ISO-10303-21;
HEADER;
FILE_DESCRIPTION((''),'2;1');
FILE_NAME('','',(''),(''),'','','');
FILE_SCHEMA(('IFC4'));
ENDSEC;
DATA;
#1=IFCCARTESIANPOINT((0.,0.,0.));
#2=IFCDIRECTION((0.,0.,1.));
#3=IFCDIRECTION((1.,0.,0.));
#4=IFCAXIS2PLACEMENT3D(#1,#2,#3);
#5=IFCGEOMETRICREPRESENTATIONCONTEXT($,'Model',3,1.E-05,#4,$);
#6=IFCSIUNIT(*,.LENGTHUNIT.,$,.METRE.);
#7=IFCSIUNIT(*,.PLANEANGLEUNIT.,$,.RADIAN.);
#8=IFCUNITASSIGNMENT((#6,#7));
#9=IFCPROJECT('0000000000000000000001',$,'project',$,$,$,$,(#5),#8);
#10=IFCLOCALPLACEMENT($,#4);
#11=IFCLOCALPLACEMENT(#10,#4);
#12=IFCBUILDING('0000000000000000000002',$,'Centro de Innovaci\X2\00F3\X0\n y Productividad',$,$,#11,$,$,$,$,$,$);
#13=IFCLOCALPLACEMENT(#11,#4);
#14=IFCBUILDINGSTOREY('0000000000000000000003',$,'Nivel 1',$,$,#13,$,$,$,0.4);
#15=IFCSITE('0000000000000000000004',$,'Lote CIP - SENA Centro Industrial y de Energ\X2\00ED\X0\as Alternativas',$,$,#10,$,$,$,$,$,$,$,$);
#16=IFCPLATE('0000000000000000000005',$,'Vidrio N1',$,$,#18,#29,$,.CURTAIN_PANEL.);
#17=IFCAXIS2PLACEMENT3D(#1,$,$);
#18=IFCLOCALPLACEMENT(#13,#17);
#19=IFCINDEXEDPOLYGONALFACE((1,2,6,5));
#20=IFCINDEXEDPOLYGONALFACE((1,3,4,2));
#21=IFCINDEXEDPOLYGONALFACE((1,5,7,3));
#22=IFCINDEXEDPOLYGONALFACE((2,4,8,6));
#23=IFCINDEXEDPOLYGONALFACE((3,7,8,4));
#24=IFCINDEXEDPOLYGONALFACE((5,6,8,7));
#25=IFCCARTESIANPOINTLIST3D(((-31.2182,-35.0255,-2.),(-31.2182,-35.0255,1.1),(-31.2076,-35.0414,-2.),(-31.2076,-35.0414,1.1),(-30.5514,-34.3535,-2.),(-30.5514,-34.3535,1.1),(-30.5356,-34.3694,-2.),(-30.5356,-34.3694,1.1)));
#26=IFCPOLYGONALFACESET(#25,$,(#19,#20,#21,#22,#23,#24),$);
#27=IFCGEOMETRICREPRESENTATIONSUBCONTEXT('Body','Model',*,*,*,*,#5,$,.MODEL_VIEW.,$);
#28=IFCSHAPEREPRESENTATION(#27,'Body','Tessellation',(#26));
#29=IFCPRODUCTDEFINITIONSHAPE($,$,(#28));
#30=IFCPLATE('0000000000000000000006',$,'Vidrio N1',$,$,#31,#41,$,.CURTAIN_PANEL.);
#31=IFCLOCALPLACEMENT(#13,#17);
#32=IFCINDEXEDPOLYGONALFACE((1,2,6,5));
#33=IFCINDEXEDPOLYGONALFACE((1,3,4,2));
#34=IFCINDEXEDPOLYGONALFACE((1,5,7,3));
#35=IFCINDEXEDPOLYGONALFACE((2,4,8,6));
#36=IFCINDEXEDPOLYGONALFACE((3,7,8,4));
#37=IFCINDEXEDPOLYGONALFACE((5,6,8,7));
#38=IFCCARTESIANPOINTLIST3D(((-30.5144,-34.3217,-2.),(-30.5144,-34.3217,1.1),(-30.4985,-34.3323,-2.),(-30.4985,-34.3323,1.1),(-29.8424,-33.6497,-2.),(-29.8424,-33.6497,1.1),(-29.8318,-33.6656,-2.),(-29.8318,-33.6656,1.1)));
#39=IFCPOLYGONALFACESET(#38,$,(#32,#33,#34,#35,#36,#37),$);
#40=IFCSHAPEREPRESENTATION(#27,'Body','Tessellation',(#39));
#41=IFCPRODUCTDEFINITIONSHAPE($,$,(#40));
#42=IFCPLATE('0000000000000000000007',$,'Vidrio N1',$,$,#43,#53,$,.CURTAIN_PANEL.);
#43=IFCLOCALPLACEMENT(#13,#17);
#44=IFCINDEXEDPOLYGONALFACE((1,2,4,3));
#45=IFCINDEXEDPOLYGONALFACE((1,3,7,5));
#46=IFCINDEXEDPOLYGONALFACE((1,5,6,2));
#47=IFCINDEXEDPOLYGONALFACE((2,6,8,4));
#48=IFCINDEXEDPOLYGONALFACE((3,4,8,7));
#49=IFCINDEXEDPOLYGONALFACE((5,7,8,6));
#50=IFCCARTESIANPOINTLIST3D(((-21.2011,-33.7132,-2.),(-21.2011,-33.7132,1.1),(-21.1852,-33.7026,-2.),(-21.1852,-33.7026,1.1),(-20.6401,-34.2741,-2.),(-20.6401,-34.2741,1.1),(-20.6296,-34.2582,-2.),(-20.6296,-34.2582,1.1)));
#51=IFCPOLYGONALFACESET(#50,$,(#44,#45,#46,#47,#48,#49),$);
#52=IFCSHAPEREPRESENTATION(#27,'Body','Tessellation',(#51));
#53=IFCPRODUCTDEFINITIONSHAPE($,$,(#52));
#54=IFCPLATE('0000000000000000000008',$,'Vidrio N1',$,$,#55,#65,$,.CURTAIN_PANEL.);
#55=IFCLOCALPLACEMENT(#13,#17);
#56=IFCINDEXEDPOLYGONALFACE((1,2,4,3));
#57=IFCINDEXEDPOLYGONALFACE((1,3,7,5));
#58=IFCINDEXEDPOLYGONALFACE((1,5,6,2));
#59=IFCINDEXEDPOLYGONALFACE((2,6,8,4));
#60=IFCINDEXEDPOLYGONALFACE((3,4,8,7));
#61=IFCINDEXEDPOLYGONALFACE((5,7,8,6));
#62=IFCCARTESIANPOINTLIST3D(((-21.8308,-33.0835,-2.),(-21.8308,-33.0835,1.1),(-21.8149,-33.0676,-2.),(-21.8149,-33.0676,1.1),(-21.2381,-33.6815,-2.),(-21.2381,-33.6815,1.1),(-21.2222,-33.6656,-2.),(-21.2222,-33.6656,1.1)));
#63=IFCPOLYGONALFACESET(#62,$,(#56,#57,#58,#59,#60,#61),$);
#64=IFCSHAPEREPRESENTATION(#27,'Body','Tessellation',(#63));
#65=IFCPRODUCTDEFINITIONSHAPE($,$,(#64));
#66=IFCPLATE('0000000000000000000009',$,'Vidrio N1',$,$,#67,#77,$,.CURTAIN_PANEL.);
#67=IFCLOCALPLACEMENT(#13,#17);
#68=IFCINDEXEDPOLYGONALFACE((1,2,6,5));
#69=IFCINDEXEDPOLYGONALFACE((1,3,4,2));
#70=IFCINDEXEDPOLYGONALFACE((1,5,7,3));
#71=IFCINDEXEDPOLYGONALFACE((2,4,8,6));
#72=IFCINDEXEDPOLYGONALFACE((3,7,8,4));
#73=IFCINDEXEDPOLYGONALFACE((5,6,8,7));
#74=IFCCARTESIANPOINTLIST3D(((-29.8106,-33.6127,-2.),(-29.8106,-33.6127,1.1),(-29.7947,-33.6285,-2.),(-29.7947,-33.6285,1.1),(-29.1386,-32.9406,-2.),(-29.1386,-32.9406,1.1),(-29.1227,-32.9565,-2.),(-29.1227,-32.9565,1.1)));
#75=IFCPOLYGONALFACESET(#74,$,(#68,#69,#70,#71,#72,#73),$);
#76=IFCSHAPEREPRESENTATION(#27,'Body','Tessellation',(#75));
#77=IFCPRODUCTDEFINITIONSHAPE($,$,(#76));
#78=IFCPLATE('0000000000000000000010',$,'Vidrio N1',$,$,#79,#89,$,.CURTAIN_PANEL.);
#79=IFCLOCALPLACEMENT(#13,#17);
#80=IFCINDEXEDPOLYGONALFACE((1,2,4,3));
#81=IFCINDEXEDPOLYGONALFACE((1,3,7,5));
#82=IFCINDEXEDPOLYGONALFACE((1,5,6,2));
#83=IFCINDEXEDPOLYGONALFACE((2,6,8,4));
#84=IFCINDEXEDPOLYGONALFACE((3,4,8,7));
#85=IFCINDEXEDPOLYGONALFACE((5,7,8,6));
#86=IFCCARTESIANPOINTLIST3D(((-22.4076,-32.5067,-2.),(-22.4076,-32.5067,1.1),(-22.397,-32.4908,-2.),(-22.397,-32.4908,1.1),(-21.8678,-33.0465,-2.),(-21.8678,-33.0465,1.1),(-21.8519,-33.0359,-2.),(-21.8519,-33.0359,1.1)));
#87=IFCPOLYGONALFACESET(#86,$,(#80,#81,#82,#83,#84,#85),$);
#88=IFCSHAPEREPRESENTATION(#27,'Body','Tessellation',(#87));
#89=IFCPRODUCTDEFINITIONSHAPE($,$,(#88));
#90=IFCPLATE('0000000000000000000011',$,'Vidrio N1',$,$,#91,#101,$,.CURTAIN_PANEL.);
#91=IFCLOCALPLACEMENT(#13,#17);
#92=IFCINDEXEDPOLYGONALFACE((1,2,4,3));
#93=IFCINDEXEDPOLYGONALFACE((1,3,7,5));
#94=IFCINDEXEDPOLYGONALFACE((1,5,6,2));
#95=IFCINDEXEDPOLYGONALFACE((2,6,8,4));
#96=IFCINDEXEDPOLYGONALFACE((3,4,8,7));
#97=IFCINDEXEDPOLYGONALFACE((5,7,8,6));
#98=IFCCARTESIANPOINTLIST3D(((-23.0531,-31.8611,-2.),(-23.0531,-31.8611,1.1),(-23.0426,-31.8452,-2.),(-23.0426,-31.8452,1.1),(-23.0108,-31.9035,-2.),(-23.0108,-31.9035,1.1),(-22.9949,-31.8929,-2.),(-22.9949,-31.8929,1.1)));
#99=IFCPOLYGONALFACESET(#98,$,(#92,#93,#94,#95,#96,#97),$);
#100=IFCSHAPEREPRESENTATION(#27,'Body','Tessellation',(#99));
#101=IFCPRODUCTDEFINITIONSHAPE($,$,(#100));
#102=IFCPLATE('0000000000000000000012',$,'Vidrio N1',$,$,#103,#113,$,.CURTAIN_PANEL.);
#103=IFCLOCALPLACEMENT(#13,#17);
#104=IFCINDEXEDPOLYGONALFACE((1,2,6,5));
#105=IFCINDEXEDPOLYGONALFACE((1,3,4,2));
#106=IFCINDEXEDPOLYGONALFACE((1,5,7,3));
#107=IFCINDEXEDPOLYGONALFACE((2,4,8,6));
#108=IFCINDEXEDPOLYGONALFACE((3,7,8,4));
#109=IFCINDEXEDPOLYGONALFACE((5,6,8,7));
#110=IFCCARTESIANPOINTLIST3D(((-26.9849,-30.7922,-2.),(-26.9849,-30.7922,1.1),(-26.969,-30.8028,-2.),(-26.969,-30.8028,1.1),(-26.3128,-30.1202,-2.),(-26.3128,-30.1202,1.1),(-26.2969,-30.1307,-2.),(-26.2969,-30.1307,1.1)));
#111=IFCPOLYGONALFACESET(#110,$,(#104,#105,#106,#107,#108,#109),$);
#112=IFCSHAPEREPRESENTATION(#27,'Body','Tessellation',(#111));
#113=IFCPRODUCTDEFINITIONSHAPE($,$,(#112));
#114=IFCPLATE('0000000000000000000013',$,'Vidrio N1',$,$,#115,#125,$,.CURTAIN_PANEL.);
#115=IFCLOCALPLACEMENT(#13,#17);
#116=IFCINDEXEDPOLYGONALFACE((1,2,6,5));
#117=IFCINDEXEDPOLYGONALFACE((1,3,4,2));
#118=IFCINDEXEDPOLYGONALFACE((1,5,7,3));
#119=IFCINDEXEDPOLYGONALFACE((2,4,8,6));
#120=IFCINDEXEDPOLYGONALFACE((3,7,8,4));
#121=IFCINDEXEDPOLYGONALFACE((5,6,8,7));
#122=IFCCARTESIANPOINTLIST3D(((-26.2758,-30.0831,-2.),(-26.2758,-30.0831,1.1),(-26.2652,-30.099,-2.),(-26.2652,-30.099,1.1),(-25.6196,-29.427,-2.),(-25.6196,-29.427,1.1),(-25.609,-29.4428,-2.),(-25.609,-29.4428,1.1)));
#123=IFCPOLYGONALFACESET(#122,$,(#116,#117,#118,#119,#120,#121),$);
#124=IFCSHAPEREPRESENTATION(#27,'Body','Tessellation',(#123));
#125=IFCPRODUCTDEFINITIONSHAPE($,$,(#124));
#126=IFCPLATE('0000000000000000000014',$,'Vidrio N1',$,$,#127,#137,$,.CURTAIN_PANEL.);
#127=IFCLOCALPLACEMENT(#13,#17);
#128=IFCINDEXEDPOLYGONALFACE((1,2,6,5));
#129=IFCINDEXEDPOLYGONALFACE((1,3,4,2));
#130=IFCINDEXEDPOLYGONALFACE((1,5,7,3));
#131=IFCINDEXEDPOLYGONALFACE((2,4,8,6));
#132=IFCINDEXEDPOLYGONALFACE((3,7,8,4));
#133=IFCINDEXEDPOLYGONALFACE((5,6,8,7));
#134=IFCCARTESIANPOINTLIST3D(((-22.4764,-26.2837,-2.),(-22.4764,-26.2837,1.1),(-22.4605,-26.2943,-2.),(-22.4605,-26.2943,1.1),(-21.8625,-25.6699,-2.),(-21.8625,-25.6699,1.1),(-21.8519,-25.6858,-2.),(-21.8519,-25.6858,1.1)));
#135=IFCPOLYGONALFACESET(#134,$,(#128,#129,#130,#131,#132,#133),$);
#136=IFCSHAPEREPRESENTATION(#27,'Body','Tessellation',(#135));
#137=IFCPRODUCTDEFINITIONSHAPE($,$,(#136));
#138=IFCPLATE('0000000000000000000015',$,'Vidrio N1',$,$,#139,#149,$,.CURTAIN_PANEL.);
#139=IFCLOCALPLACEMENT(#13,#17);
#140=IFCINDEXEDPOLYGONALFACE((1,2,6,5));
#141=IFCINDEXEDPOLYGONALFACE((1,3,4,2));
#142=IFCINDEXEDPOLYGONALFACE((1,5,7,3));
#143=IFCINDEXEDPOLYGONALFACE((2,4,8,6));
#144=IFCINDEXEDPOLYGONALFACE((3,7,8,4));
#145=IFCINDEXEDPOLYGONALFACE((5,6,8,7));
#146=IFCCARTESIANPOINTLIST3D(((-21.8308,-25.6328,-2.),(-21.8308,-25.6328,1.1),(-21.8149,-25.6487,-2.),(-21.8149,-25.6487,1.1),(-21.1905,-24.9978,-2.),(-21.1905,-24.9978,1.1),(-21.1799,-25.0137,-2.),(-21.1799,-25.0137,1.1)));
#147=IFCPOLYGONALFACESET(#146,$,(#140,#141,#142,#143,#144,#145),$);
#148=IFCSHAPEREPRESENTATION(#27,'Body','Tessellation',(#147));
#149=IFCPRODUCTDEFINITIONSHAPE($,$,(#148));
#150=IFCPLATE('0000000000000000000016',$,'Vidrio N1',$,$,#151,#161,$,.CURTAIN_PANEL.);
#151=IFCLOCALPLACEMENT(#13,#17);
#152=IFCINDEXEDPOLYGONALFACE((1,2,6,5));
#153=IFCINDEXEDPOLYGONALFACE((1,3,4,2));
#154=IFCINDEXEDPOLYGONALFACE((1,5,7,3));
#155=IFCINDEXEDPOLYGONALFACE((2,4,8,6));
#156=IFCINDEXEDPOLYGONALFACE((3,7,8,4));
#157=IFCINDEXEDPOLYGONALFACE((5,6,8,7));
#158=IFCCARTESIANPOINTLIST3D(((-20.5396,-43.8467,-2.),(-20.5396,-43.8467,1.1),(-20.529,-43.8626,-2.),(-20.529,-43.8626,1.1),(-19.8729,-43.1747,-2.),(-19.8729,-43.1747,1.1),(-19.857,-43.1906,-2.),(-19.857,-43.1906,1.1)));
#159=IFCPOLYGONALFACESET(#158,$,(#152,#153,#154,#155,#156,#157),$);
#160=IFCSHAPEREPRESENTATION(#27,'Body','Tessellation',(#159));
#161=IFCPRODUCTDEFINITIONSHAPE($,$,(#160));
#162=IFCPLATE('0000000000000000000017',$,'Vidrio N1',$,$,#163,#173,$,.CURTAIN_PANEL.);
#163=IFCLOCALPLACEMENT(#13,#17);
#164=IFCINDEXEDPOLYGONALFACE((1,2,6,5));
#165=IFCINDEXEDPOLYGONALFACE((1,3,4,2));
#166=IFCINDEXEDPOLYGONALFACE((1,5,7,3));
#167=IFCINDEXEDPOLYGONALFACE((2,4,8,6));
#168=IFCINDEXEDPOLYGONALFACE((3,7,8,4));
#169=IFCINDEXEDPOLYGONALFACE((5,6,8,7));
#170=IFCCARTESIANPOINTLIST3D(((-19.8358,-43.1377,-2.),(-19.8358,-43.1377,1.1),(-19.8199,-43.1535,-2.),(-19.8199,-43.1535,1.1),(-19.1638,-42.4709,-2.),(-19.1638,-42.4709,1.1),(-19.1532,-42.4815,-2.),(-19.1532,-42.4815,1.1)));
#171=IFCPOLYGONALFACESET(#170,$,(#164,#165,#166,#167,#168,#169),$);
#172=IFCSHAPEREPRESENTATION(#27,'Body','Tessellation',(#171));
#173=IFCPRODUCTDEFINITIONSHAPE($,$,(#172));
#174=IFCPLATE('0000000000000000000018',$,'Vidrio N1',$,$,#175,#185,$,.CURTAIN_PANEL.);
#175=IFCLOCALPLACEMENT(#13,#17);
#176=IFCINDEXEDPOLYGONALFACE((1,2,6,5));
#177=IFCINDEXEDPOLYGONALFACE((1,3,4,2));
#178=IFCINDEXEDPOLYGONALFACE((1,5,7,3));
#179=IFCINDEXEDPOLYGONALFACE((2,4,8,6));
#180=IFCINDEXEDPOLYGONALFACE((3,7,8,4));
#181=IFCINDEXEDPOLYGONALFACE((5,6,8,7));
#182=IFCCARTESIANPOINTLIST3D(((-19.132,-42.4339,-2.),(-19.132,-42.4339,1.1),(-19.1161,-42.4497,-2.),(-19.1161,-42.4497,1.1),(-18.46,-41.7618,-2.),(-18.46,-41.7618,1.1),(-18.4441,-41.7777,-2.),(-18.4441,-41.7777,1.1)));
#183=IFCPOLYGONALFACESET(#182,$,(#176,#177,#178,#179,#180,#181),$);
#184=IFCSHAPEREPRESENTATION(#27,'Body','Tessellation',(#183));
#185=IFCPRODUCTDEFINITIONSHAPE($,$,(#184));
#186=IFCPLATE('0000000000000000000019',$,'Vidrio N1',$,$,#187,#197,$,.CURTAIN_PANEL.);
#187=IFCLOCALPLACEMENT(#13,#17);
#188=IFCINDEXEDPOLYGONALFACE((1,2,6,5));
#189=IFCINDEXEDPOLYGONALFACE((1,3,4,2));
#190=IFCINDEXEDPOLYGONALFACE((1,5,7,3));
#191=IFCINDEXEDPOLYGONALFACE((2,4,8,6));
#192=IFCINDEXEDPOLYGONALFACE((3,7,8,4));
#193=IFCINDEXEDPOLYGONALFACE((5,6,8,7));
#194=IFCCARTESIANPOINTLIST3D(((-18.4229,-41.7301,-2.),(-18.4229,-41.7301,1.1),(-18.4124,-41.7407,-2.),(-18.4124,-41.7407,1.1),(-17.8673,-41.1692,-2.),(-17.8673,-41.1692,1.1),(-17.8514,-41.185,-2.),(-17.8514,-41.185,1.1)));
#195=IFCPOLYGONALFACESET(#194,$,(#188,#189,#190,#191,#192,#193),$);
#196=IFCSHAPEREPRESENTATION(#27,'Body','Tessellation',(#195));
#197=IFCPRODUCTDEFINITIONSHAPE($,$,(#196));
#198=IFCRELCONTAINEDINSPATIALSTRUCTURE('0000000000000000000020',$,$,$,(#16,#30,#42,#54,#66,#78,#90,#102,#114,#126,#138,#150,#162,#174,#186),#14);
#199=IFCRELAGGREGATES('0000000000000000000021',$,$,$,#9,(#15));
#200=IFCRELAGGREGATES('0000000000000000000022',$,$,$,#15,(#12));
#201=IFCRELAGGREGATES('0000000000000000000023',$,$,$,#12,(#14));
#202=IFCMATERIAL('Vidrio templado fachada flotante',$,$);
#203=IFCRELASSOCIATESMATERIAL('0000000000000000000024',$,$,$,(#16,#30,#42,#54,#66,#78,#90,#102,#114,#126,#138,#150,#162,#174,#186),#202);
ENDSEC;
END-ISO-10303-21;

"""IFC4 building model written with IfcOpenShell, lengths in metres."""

from ifc_helpers import new_model, si_unit, frame, origin_with_axes, place, context, subcontext, project, spatial, polyline, outline, extrude, material, element, save


model = new_model("IFC4")

# Units and contexts
model_context = context("Model", 3, precision=1e-05, world=origin_with_axes())
body_context = subcontext(model_context, "Body", "Model", "MODEL_VIEW")
ifc_project = project(units=[si_unit("LENGTHUNIT", "METRE"), si_unit("PLANEANGLEUNIT", "RADIAN")], contexts=[model_context])

# Site, building, storey
site_placement = place(None, origin_with_axes())
site = spatial("IfcSite", under=ifc_project, at=site_placement, Name="Lote CIP - SENA Centro Industrial y de Energías Alternativas")
building_placement = place(site_placement, origin_with_axes())
building = spatial("IfcBuilding", under=site, at=building_placement, Name="Centro de Innovación y Productividad")
storey_placement = place(building_placement, origin_with_axes())
storey = spatial("IfcBuildingStorey", under=building, at=storey_placement, Name="Nivel 1", Elevation=0.4)

# Plates
ifc_material = material(Name="Vidrio templado fachada flotante")
plate_1_placement = place(storey_placement, frame((0.0, 0.0, -2.4), z_axis=(0.0, 0.0, 1.0), x_axis=(1.0, 0.0, 0.0)))
element("IfcPlate", 1, at=plate_1_placement, inside=storey, material=ifc_material, Name="Vidrio N1", PredefinedType="CURTAIN_PANEL", context=body_context, shape_type="SweptSolid", body=[
    extrude(outline(polyline([(-30.5356, -34.3694), (-31.2076, -35.0414), (-31.2182, -35.0255), (-30.5514, -34.3535), (-30.5356, -34.3694)])), frame((0.0, 0.0, 0.4)), (0.0, 0.0, 1.0), 3.1),
])
plate_2_placement = place(storey_placement, frame((0.0, 0.0, -2.4), z_axis=(0.0, 0.0, 1.0), x_axis=(1.0, 0.0, 0.0)))
element("IfcPlate", 2, at=plate_2_placement, inside=storey, material=ifc_material, Name="Vidrio N1", PredefinedType="CURTAIN_PANEL", context=body_context, shape_type="SweptSolid", body=[
    extrude(outline(polyline([(-29.8318, -33.6656), (-30.4985, -34.3323), (-30.5144, -34.3217), (-29.8424, -33.6497), (-29.8318, -33.6656)])), frame((0.0, 0.0, 0.4)), (0.0, 0.0, 1.0), 3.1),
])
plate_3_placement = place(storey_placement, frame((0.0, 0.0, -2.4), z_axis=(0.0, 0.0, 1.0), x_axis=(1.0, 0.0, 0.0)))
element("IfcPlate", 3, at=plate_3_placement, inside=storey, material=ifc_material, Name="Vidrio N1", PredefinedType="CURTAIN_PANEL", context=body_context, shape_type="SweptSolid", body=[
    extrude(outline(polyline([(-20.6296, -34.2582), (-20.6401, -34.2741), (-21.2011, -33.7132), (-21.1852, -33.7026), (-20.6296, -34.2582)])), frame((0.0, 0.0, 0.4)), (0.0, 0.0, 1.0), 3.1),
])
plate_4_placement = place(storey_placement, frame((0.0, 0.0, -2.4), z_axis=(0.0, 0.0, 1.0), x_axis=(1.0, 0.0, 0.0)))
element("IfcPlate", 4, at=plate_4_placement, inside=storey, material=ifc_material, Name="Vidrio N1", PredefinedType="CURTAIN_PANEL", context=body_context, shape_type="SweptSolid", body=[
    extrude(outline(polyline([(-21.2381, -33.6815), (-21.8308, -33.0835), (-21.8149, -33.0676), (-21.2222, -33.6656), (-21.2381, -33.6815)])), frame((0.0, 0.0, 0.4)), (0.0, 0.0, 1.0), 3.1),
])
plate_5_placement = place(storey_placement, frame((0.0, 0.0, -2.4), z_axis=(0.0, 0.0, 1.0), x_axis=(1.0, 0.0, 0.0)))
element("IfcPlate", 5, at=plate_5_placement, inside=storey, material=ifc_material, Name="Vidrio N1", PredefinedType="CURTAIN_PANEL", context=body_context, shape_type="SweptSolid", body=[
    extrude(outline(polyline([(-29.1227, -32.9565), (-29.7947, -33.6285), (-29.8106, -33.6127), (-29.1386, -32.9406), (-29.1227, -32.9565)])), frame((0.0, 0.0, 0.4)), (0.0, 0.0, 1.0), 3.1),
])
plate_6_placement = place(storey_placement, frame((0.0, 0.0, -2.4), z_axis=(0.0, 0.0, 1.0), x_axis=(1.0, 0.0, 0.0)))
element("IfcPlate", 6, at=plate_6_placement, inside=storey, material=ifc_material, Name="Vidrio N1", PredefinedType="CURTAIN_PANEL", context=body_context, shape_type="SweptSolid", body=[
    extrude(outline(polyline([(-21.8678, -33.0465), (-22.4076, -32.5067), (-22.397, -32.4908), (-21.8519, -33.0359), (-21.8678, -33.0465)])), frame((0.0, 0.0, 0.4)), (0.0, 0.0, 1.0), 3.1),
])
plate_7_placement = place(storey_placement, frame((0.0, 0.0, -2.4), z_axis=(0.0, 0.0, 1.0), x_axis=(1.0, 0.0, 0.0)))
element("IfcPlate", 7, at=plate_7_placement, inside=storey, material=ifc_material, Name="Vidrio N1", PredefinedType="CURTAIN_PANEL", context=body_context, shape_type="SweptSolid", body=[
    extrude(outline(polyline([(-23.0426, -31.8452), (-22.9949, -31.8929), (-23.0108, -31.9035), (-23.0531, -31.8611), (-23.0426, -31.8452)])), frame((0.0, 0.0, 0.4)), (0.0, 0.0, 1.0), 3.1),
])
plate_8_placement = place(storey_placement, frame((0.0, 0.0, -2.4), z_axis=(0.0, 0.0, 1.0), x_axis=(1.0, 0.0, 0.0)))
element("IfcPlate", 8, at=plate_8_placement, inside=storey, material=ifc_material, Name="Vidrio N1", PredefinedType="CURTAIN_PANEL", context=body_context, shape_type="SweptSolid", body=[
    extrude(outline(polyline([(-26.969, -30.8028), (-26.9849, -30.7922), (-26.3128, -30.1202), (-26.2969, -30.1307), (-26.969, -30.8028)])), frame((0.0, 0.0, 0.4)), (0.0, 0.0, 1.0), 3.1),
])
plate_9_placement = place(storey_placement, frame((0.0, 0.0, -2.4), z_axis=(0.0, 0.0, 1.0), x_axis=(1.0, 0.0, 0.0)))
element("IfcPlate", 9, at=plate_9_placement, inside=storey, material=ifc_material, Name="Vidrio N1", PredefinedType="CURTAIN_PANEL", context=body_context, shape_type="SweptSolid", body=[
    extrude(outline(polyline([(-25.609, -29.4428), (-26.2652, -30.099), (-26.2758, -30.0831), (-25.6196, -29.427), (-25.609, -29.4428)])), frame((0.0, 0.0, 0.4)), (0.0, 0.0, 1.0), 3.1),
])
plate_10_placement = place(storey_placement, frame((0.0, 0.0, -2.4), z_axis=(0.0, 0.0, 1.0), x_axis=(1.0, 0.0, 0.0)))
element("IfcPlate", 10, at=plate_10_placement, inside=storey, material=ifc_material, Name="Vidrio N1", PredefinedType="CURTAIN_PANEL", context=body_context, shape_type="SweptSolid", body=[
    extrude(outline(polyline([(-22.4764, -26.2837), (-21.8625, -25.6699), (-21.8519, -25.6857), (-22.4605, -26.2943), (-22.4764, -26.2837)])), frame((0.0, 0.0, 0.4)), (0.0, 0.0, 1.0), 3.1),
])
plate_11_placement = place(storey_placement, frame((0.0, 0.0, -2.4), z_axis=(0.0, 0.0, 1.0), x_axis=(1.0, 0.0, 0.0)))
element("IfcPlate", 11, at=plate_11_placement, inside=storey, material=ifc_material, Name="Vidrio N1", PredefinedType="CURTAIN_PANEL", context=body_context, shape_type="SweptSolid", body=[
    extrude(outline(polyline([(-21.8149, -25.6487), (-21.8308, -25.6328), (-21.1905, -24.9978), (-21.1799, -25.0137), (-21.8149, -25.6487)])), frame((0.0, 0.0, 0.4)), (0.0, 0.0, 1.0), 3.1),
])
plate_12_placement = place(storey_placement, frame((0.0, 0.0, -2.4), z_axis=(0.0, 0.0, 1.0), x_axis=(1.0, 0.0, 0.0)))
element("IfcPlate", 12, at=plate_12_placement, inside=storey, material=ifc_material, Name="Vidrio N1", PredefinedType="CURTAIN_PANEL", context=body_context, shape_type="SweptSolid", body=[
    extrude(outline(polyline([(-20.529, -43.8626), (-20.5396, -43.8467), (-19.8729, -43.1747), (-19.857, -43.1906), (-20.529, -43.8626)])), frame((0.0, 0.0, 0.4)), (0.0, 0.0, 1.0), 3.1),
])
plate_13_placement = place(storey_placement, frame((0.0, 0.0, -2.4), z_axis=(0.0, 0.0, 1.0), x_axis=(1.0, 0.0, 0.0)))
element("IfcPlate", 13, at=plate_13_placement, inside=storey, material=ifc_material, Name="Vidrio N1", PredefinedType="CURTAIN_PANEL", context=body_context, shape_type="SweptSolid", body=[
    extrude(outline(polyline([(-19.8199, -43.1535), (-19.8358, -43.1377), (-19.1638, -42.4709), (-19.1532, -42.4815), (-19.8199, -43.1535)])), frame((0.0, 0.0, 0.4)), (0.0, 0.0, 1.0), 3.1),
])
plate_14_placement = place(storey_placement, frame((0.0, 0.0, -2.4), z_axis=(0.0, 0.0, 1.0), x_axis=(1.0, 0.0, 0.0)))
element("IfcPlate", 14, at=plate_14_placement, inside=storey, material=ifc_material, Name="Vidrio N1", PredefinedType="CURTAIN_PANEL", context=body_context, shape_type="SweptSolid", body=[
    extrude(outline(polyline([(-18.4441, -41.7777), (-19.1161, -42.4497), (-19.132, -42.4339), (-18.46, -41.7618), (-18.4441, -41.7777)])), frame((0.0, 0.0, 0.4)), (0.0, 0.0, 1.0), 3.1),
])
plate_15_placement = place(storey_placement, frame((0.0, 0.0, -2.4), z_axis=(0.0, 0.0, 1.0), x_axis=(1.0, 0.0, 0.0)))
element("IfcPlate", 15, at=plate_15_placement, inside=storey, material=ifc_material, Name="Vidrio N1", PredefinedType="CURTAIN_PANEL", context=body_context, shape_type="SweptSolid", body=[
    extrude(outline(polyline([(-17.8514, -41.185), (-18.4124, -41.7407), (-18.4229, -41.7301), (-17.8673, -41.1692), (-17.8514, -41.185)])), frame((0.0, 0.0, 0.4)), (0.0, 0.0, 1.0), 3.1),
])

save(model, "model.ifc")
